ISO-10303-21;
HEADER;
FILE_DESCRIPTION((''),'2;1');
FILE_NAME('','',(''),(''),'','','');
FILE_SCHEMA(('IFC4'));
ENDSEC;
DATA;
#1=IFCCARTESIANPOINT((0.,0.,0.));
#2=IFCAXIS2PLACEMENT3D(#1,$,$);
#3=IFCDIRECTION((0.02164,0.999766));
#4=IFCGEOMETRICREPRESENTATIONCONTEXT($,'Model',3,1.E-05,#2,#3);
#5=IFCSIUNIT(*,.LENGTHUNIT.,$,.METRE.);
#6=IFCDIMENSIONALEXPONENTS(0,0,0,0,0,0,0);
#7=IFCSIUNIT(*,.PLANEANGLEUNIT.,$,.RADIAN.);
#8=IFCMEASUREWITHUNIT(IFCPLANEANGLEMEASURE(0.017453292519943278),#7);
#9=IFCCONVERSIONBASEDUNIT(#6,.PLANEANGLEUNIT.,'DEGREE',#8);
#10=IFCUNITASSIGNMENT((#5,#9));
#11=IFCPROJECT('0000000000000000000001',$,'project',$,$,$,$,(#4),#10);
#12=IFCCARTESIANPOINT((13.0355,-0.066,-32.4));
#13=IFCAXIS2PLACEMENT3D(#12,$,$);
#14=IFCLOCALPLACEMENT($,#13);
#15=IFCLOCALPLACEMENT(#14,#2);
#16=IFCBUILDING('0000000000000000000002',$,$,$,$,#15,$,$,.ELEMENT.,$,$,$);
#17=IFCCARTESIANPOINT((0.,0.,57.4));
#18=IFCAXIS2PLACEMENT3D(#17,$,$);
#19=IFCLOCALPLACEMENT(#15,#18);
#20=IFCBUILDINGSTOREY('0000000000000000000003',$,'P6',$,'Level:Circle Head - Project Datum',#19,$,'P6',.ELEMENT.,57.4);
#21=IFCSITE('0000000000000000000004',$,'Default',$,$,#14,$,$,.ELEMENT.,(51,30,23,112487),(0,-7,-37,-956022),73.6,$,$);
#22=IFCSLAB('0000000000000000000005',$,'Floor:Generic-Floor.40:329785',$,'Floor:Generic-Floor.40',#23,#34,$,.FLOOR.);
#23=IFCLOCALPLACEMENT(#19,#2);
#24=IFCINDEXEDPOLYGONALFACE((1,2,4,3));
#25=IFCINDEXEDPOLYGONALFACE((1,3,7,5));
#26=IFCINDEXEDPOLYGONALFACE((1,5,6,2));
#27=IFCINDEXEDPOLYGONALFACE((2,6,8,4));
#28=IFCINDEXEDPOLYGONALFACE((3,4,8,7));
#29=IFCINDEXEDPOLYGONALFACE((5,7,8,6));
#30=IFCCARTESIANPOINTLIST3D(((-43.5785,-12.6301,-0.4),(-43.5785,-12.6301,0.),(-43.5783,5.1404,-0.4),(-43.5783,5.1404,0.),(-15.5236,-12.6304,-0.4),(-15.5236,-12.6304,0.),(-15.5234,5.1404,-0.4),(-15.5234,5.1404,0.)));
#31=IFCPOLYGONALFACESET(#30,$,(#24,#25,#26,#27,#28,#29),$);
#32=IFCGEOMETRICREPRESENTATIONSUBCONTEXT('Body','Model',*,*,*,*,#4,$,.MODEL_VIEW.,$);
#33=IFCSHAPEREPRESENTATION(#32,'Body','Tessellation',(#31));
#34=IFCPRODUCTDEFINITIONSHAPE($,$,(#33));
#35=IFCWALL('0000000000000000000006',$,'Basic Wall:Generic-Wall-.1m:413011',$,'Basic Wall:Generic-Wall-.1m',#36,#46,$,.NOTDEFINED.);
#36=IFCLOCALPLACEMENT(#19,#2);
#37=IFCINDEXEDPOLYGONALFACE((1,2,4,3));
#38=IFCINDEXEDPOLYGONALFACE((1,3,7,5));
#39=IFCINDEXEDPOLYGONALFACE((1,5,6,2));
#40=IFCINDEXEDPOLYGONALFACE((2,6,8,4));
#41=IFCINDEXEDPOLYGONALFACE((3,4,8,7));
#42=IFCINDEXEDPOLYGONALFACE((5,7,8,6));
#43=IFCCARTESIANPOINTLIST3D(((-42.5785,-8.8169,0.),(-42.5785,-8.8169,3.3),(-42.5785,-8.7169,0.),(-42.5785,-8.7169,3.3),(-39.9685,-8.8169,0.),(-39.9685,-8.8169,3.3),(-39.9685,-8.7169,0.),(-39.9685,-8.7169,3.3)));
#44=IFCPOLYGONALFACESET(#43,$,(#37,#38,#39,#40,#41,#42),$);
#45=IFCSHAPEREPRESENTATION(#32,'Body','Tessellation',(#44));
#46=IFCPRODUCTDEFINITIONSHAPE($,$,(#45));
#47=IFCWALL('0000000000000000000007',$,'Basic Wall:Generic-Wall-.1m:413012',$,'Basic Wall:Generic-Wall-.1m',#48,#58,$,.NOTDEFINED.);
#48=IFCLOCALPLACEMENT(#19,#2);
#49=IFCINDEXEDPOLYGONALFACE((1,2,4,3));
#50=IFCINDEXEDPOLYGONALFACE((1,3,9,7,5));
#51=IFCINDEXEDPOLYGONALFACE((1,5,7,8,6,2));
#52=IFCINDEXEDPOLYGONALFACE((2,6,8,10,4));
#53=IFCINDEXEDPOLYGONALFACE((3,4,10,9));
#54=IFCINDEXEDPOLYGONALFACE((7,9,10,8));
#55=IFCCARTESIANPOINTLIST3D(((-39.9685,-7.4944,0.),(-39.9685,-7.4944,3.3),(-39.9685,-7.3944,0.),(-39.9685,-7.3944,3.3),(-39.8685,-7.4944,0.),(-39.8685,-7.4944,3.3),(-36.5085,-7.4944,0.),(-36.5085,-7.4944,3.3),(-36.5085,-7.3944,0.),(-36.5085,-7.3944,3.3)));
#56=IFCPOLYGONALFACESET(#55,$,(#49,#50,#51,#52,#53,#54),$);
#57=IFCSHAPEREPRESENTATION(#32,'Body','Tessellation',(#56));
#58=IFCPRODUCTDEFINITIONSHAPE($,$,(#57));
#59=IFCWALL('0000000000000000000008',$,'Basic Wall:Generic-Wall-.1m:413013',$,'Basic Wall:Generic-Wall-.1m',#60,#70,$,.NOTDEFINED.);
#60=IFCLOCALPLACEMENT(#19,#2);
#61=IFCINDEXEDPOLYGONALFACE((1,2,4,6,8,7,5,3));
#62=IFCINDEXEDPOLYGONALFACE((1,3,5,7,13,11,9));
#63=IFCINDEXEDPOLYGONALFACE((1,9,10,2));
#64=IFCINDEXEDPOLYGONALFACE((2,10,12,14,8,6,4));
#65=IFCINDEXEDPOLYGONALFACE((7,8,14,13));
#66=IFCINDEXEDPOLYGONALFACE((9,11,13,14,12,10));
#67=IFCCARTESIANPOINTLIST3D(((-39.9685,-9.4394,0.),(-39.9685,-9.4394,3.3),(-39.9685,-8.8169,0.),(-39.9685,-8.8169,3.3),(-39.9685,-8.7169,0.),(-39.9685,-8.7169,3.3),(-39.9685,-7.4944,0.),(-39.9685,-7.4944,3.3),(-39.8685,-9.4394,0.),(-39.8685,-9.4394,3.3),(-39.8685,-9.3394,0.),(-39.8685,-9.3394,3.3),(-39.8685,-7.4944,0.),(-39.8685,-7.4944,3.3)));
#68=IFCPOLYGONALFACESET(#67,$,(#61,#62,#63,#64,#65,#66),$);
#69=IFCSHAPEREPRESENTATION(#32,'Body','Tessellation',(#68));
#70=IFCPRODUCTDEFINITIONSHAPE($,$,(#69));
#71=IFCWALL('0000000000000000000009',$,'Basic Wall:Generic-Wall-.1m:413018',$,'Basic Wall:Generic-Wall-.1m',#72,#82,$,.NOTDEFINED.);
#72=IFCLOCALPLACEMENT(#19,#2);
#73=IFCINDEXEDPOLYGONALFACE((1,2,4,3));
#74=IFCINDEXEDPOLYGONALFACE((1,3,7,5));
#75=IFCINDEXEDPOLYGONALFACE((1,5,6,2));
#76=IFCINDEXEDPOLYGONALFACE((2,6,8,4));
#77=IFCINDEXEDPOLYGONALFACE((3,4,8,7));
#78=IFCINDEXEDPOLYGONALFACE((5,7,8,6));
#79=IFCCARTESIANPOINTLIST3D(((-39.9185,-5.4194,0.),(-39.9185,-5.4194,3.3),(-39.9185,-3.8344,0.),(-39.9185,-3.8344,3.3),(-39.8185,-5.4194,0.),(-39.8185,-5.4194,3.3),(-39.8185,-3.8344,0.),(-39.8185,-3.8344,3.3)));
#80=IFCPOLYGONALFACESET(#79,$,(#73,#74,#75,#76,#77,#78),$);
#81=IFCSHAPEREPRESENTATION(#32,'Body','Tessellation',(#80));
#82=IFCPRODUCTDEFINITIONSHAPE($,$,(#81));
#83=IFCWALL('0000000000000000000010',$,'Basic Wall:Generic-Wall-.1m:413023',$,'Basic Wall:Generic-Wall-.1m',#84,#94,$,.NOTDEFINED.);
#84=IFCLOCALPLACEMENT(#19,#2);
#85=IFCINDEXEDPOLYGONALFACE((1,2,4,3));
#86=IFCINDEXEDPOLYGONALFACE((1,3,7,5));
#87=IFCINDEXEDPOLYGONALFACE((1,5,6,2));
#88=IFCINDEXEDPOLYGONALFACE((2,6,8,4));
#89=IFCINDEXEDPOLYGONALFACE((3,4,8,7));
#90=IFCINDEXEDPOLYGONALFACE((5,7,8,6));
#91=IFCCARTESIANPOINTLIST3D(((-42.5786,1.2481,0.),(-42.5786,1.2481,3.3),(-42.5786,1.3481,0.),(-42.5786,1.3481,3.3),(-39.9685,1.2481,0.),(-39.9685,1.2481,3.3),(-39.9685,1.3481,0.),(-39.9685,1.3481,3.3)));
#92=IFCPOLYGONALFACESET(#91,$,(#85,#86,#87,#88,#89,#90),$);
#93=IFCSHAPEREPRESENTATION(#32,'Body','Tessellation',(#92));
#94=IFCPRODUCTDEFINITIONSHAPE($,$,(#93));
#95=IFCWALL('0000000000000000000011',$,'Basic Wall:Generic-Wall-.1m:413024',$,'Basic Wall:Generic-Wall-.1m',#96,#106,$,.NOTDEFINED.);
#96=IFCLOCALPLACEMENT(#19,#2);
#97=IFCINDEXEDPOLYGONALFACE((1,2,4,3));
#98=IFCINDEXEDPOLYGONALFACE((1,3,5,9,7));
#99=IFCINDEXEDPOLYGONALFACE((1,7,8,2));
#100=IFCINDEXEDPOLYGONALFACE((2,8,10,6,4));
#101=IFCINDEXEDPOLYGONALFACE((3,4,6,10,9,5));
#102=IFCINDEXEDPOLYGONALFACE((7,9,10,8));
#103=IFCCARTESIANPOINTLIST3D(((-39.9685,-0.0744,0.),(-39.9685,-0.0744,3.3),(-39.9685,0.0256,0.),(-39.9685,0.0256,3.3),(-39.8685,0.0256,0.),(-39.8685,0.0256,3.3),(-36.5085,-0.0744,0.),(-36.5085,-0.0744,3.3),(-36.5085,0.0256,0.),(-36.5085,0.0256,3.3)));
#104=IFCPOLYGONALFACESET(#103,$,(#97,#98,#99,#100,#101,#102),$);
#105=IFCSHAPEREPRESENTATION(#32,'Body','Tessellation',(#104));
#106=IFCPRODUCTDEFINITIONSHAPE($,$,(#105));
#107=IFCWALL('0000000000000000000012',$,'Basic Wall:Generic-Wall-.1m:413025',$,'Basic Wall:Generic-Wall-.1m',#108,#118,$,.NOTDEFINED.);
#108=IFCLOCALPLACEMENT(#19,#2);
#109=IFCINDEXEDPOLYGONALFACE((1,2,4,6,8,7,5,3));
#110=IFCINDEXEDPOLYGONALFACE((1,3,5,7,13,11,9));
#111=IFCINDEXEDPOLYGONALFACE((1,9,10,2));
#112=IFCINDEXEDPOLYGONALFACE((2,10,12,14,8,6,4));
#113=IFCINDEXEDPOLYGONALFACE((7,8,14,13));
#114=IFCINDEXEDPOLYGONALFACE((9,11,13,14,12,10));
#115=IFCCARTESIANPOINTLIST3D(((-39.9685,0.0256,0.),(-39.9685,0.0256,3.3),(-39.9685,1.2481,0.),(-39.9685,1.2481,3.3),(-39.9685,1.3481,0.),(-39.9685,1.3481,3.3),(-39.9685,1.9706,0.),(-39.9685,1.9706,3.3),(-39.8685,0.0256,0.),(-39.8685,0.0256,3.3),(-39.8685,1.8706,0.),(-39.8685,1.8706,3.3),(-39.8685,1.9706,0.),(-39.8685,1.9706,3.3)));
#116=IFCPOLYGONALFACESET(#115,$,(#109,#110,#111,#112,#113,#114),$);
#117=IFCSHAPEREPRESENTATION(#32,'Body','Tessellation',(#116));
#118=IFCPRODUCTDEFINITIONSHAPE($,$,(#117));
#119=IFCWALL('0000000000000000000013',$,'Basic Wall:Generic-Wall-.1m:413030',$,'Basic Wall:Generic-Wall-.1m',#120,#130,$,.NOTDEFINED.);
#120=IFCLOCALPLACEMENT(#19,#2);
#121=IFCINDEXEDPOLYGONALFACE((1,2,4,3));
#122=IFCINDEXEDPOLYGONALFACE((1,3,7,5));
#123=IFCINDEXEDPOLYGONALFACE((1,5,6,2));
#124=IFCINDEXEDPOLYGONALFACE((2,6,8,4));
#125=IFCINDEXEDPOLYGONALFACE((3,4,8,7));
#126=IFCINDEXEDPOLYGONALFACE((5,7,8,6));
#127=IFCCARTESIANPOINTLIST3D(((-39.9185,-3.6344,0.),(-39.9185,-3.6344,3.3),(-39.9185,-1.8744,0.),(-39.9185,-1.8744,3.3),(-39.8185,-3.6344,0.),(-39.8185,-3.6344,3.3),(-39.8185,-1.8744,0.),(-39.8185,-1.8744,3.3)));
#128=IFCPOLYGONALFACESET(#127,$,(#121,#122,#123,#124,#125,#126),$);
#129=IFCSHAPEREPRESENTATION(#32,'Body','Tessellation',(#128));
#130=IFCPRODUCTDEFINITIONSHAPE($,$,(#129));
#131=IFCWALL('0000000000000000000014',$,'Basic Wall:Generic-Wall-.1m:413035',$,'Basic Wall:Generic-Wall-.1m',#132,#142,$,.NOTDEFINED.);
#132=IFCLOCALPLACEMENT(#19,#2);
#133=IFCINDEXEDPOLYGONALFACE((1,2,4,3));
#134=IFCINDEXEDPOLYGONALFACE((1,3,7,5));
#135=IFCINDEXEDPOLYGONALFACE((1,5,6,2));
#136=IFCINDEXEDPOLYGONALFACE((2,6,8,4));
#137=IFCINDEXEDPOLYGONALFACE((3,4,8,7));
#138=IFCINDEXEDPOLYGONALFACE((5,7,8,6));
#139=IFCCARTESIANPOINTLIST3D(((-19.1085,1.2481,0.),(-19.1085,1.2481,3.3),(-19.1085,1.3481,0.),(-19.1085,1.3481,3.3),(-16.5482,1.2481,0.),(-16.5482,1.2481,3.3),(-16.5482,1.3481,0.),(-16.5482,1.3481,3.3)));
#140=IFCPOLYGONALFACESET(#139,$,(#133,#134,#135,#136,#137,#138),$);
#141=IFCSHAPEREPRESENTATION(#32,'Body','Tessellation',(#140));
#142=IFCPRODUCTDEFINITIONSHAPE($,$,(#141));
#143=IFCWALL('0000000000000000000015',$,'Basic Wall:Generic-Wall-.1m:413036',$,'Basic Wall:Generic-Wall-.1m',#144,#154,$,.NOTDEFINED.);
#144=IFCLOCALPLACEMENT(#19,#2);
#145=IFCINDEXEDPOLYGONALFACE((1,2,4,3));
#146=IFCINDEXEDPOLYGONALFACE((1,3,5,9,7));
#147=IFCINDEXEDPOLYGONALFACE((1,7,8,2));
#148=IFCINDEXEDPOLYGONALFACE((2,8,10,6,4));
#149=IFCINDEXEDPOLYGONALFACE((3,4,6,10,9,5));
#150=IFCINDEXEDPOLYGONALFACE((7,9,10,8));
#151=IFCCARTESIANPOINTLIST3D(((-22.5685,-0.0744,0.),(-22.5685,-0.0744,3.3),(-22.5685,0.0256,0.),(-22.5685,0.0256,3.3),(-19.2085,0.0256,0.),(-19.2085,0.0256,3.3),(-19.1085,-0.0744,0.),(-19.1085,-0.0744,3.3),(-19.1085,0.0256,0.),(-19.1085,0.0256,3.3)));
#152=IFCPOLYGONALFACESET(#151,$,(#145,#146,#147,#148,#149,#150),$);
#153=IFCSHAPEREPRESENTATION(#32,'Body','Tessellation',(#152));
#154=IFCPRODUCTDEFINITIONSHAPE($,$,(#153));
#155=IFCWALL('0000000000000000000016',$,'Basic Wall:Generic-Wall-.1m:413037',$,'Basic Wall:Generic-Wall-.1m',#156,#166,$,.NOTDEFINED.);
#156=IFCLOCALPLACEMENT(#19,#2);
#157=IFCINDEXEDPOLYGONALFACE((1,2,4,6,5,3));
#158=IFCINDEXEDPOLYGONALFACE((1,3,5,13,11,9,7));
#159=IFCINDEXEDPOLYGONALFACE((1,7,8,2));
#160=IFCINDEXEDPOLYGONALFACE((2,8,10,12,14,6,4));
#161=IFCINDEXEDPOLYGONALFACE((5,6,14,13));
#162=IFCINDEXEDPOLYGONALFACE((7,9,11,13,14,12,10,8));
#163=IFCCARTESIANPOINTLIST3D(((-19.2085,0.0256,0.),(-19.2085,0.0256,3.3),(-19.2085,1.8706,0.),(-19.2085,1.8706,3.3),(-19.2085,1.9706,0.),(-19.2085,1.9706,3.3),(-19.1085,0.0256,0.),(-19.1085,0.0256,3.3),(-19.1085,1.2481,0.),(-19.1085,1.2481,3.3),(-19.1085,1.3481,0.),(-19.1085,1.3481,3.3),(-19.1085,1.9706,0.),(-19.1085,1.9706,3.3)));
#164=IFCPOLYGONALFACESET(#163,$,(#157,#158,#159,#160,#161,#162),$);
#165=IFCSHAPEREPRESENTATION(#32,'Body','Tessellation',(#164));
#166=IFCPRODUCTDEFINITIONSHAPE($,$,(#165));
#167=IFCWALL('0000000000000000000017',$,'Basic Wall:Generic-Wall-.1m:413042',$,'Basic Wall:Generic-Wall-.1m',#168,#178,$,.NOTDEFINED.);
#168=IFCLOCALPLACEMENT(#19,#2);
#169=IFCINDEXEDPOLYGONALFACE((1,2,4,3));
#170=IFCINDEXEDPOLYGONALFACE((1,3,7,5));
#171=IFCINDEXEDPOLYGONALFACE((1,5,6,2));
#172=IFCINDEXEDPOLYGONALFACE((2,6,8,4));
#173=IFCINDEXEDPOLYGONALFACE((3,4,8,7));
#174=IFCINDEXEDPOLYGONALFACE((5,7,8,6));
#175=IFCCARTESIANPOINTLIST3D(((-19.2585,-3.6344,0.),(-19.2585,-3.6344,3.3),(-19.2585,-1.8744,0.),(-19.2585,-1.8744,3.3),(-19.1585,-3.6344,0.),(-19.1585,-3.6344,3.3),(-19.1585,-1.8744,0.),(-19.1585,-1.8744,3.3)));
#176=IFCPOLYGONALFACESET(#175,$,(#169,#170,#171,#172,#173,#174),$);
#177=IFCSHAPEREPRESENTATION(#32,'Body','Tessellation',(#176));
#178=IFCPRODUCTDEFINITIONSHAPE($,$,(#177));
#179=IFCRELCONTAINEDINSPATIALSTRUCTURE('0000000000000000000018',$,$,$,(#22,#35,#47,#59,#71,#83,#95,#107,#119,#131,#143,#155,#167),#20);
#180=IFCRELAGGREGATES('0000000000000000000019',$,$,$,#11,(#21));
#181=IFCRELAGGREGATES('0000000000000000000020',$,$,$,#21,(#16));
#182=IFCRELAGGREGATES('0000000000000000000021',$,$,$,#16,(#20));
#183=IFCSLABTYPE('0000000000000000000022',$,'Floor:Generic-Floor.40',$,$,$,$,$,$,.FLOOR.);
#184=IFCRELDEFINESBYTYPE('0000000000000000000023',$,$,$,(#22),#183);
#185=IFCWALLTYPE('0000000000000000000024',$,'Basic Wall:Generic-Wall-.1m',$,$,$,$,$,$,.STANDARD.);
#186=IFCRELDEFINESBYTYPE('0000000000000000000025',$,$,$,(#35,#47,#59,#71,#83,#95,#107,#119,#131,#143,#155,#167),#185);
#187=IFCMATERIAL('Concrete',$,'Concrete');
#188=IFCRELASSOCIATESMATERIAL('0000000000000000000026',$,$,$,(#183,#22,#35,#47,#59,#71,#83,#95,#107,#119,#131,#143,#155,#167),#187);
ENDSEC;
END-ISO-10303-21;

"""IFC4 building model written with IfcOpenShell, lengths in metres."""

from ifc_helpers import new_model, entity, si_unit, converted_unit, direction, frame, origin, place, context, subcontext, project, spatial, indexed_curve, outline, extrude, material, type_object, element, save


model = new_model("IFC4")

# Units and contexts
model_context = context("Model", 3, precision=1e-05, world=origin(), true_north=direction((0.02164, 0.999766)))
body_context = subcontext(model_context, "Body", "Model", "MODEL_VIEW")
ifc_project = project(units=[si_unit("LENGTHUNIT", "METRE"), converted_unit("PLANEANGLEUNIT", "DEGREE", entity("IfcPlaneAngleMeasure", 0.017453292519943278), si_unit("PLANEANGLEUNIT", "RADIAN"), dimensions=[0, 0, 0, 0, 0, 0, 0])], contexts=[model_context])

# Site, building, storey
site_placement = place(None, frame((13.0355, -0.066, -32.4)))
site = spatial("IfcSite", under=ifc_project, at=site_placement, Name="Default", CompositionType="ELEMENT", RefLatitude=(51, 30, 23, 112487), RefLongitude=(0, -7, -37, -956022), RefElevation=73.6)
building_placement = place(site_placement, origin())
building = spatial("IfcBuilding", under=site, at=building_placement, CompositionType="ELEMENT")
storey_placement = place(building_placement, frame((0.0, 0.0, 57.4)))
storey = spatial("IfcBuildingStorey", under=building, at=storey_placement, Name="P6", ObjectType="Level:Circle Head - Project Datum", LongName="P6", CompositionType="ELEMENT", Elevation=57.4)

# Shared definitions
ifc_material = material(Name="Concrete", Category="Concrete")

# Slab
slab_type = type_object("IfcSlabType", Name="Floor:Generic-Floor.40", PredefinedType="FLOOR", material=ifc_material)
slab_placement = place(storey_placement, origin())
element("IfcSlab", 1, at=slab_placement, inside=storey, type_object=slab_type, material=ifc_material, Name="Floor:Generic-Floor.40:329785", ObjectType="Floor:Generic-Floor.40", PredefinedType="FLOOR", context=body_context, shape_type="SweptSolid", body=[
    extrude(outline(indexed_curve([(-14.0274, -8.8853), (14.0275, -8.8853), (14.0274, 8.8855), (-14.0275, 8.8852), (-14.0274, -8.8853)], self_intersect=False)), frame((-29.5509, -3.7449, 0.0), z_axis=(0.0, 0.0, -1.0), x_axis=(1.0, 0.0, 0.0)), (0.0, 0.0, 1.0), 0.4),
])

# Walls
wall_type = type_object("IfcWallType", Name="Basic Wall:Generic-Wall-.1m", PredefinedType="STANDARD")
wall_1_placement = place(storey_placement, frame((-39.9685, -8.7669, 0.0), z_axis=(0.0, 0.0, 1.0), x_axis=(-1.0, 0.0, 0.0)))
element("IfcWall", 2, at=wall_1_placement, inside=storey, type_object=wall_type, material=ifc_material, Name="Basic Wall:Generic-Wall-.1m:413011", ObjectType="Basic Wall:Generic-Wall-.1m", PredefinedType="NOTDEFINED", context=body_context, shape_type="SweptSolid", body=[
    extrude(outline(indexed_curve([(2.61, -0.05), (2.61, 0.05), (0.0, 0.05), (0.0, -0.05), (2.61, -0.05)], self_intersect=False)), origin(), (0.0, 0.0, 1.0), 3.3),
])
wall_2_placement = place(storey_placement, frame((-36.5085, -7.4444, 0.0), z_axis=(0.0, 0.0, 1.0), x_axis=(-1.0, 0.0, 0.0)))
element("IfcWall", 3, at=wall_2_placement, inside=storey, type_object=wall_type, material=ifc_material, Name="Basic Wall:Generic-Wall-.1m:413012", ObjectType="Basic Wall:Generic-Wall-.1m", PredefinedType="NOTDEFINED", context=body_context, shape_type="SweptSolid", body=[
    extrude(outline(indexed_curve([(3.46, -0.05), (3.46, 0.05), (3.36, 0.05), (0.0, 0.05), (0.0, -0.05), (3.46, -0.05)], self_intersect=False)), origin(), (0.0, 0.0, 1.0), 3.3),
])
wall_3_placement = place(storey_placement, frame((-39.9185, -7.4944, 0.0), z_axis=(0.0, 0.0, 1.0), x_axis=(0.0, -1.0, 0.0)))
element("IfcWall", 4, at=wall_3_placement, inside=storey, type_object=wall_type, material=ifc_material, Name="Basic Wall:Generic-Wall-.1m:413013", ObjectType="Basic Wall:Generic-Wall-.1m", PredefinedType="NOTDEFINED", context=body_context, shape_type="SweptSolid", body=[
    extrude(outline(indexed_curve([(1.945, -0.05), (1.945, 0.05), (1.845, 0.05), (0.0, 0.05), (0.0, -0.05), (1.2225, -0.05), (1.3225, -0.05), (1.945, -0.05)], self_intersect=False)), origin(), (0.0, 0.0, 1.0), 3.3),
])
wall_4_placement = place(storey_placement, frame((-39.8685, -5.4194, 0.0), z_axis=(0.0, 0.0, 1.0), x_axis=(0.0, 1.0, 0.0)))
element("IfcWall", 5, at=wall_4_placement, inside=storey, type_object=wall_type, material=ifc_material, Name="Basic Wall:Generic-Wall-.1m:413018", ObjectType="Basic Wall:Generic-Wall-.1m", PredefinedType="NOTDEFINED", context=body_context, shape_type="SweptSolid", body=[
    extrude(outline(indexed_curve([(1.585, -0.05), (1.585, 0.05), (0.0, 0.05), (0.0, -0.05), (1.585, -0.05)], self_intersect=False)), origin(), (0.0, 0.0, 1.0), 3.3),
])
wall_5_placement = place(storey_placement, frame((-39.9685, 1.2981, 0.0), z_axis=(0.0, 0.0, 1.0), x_axis=(-1.0, 0.0, 0.0)))
element("IfcWall", 6, at=wall_5_placement, inside=storey, type_object=wall_type, material=ifc_material, Name="Basic Wall:Generic-Wall-.1m:413023", ObjectType="Basic Wall:Generic-Wall-.1m", PredefinedType="NOTDEFINED", context=body_context, shape_type="SweptSolid", body=[
    extrude(outline(indexed_curve([(2.6101, -0.05), (2.6101, 0.05), (0.0, 0.05), (0.0, -0.05), (2.6101, -0.05)], self_intersect=False)), origin(), (0.0, 0.0, 1.0), 3.3),
])
wall_6_placement = place(storey_placement, frame((-36.5085, -0.0244, 0.0), z_axis=(0.0, 0.0, 1.0), x_axis=(-1.0, 0.0, 0.0)))
element("IfcWall", 7, at=wall_6_placement, inside=storey, type_object=wall_type, material=ifc_material, Name="Basic Wall:Generic-Wall-.1m:413024", ObjectType="Basic Wall:Generic-Wall-.1m", PredefinedType="NOTDEFINED", context=body_context, shape_type="SweptSolid", body=[
    extrude(outline(indexed_curve([(3.46, -0.05), (3.46, 0.05), (0.0, 0.05), (0.0, -0.05), (3.36, -0.05), (3.46, -0.05)], self_intersect=False)), origin(), (0.0, 0.0, 1.0), 3.3),
])
wall_7_placement = place(storey_placement, frame((-39.9185, 0.0256, 0.0), z_axis=(0.0, 0.0, 1.0), x_axis=(0.0, 1.0, 0.0)))
element("IfcWall", 8, at=wall_7_placement, inside=storey, type_object=wall_type, material=ifc_material, Name="Basic Wall:Generic-Wall-.1m:413025", ObjectType="Basic Wall:Generic-Wall-.1m", PredefinedType="NOTDEFINED", context=body_context, shape_type="SweptSolid", body=[
    extrude(outline(indexed_curve([(1.945, -0.05), (1.945, 0.05), (1.3225, 0.05), (1.2225, 0.05), (0.0, 0.05), (0.0, -0.05), (1.845, -0.05), (1.945, -0.05)], self_intersect=False)), origin(), (0.0, 0.0, 1.0), 3.3),
])
wall_8_placement = place(storey_placement, frame((-39.8685, -1.8744, 0.0), z_axis=(0.0, 0.0, 1.0), x_axis=(0.0, -1.0, 0.0)))
element("IfcWall", 9, at=wall_8_placement, inside=storey, type_object=wall_type, material=ifc_material, Name="Basic Wall:Generic-Wall-.1m:413030", ObjectType="Basic Wall:Generic-Wall-.1m", PredefinedType="NOTDEFINED", context=body_context, shape_type="SweptSolid", body=[
    extrude(outline(indexed_curve([(1.76, -0.05), (1.76, 0.05), (0.0, 0.05), (0.0, -0.05), (1.76, -0.05)], self_intersect=False)), origin(), (0.0, 0.0, 1.0), 3.3),
])
wall_9_placement = place(storey_placement, frame((-19.1085, 1.2981, 0.0)))
element("IfcWall", 10, at=wall_9_placement, inside=storey, type_object=wall_type, material=ifc_material, Name="Basic Wall:Generic-Wall-.1m:413035", ObjectType="Basic Wall:Generic-Wall-.1m", PredefinedType="NOTDEFINED", context=body_context, shape_type="SweptSolid", body=[
    extrude(outline(indexed_curve([(2.5602, -0.05), (2.5602, 0.05), (0.0, 0.05), (0.0, -0.05), (2.5602, -0.05)], self_intersect=False)), origin(), (0.0, 0.0, 1.0), 3.3),
])
wall_10_placement = place(storey_placement, frame((-22.5685, -0.0244, 0.0)))
element("IfcWall", 11, at=wall_10_placement, inside=storey, type_object=wall_type, material=ifc_material, Name="Basic Wall:Generic-Wall-.1m:413036", ObjectType="Basic Wall:Generic-Wall-.1m", PredefinedType="NOTDEFINED", context=body_context, shape_type="SweptSolid", body=[
    extrude(outline(indexed_curve([(3.46, -0.05), (3.46, 0.05), (3.36, 0.05), (0.0, 0.05), (0.0, -0.05), (3.46, -0.05)], self_intersect=False)), origin(), (0.0, 0.0, 1.0), 3.3),
])
wall_11_placement = place(storey_placement, frame((-19.1585, 0.0256, 0.0), z_axis=(0.0, 0.0, 1.0), x_axis=(0.0, 1.0, 0.0)))
element("IfcWall", 12, at=wall_11_placement, inside=storey, type_object=wall_type, material=ifc_material, Name="Basic Wall:Generic-Wall-.1m:413037", ObjectType="Basic Wall:Generic-Wall-.1m", PredefinedType="NOTDEFINED", context=body_context, shape_type="SweptSolid", body=[
    extrude(outline(indexed_curve([(1.945, -0.05), (1.945, 0.05), (1.845, 0.05), (0.0, 0.05), (0.0, -0.05), (1.2225, -0.05), (1.3225, -0.05), (1.945, -0.05)], self_intersect=False)), origin(), (0.0, 0.0, 1.0), 3.3),
])
wall_12_placement = place(storey_placement, frame((-19.2085, -1.8744, 0.0), z_axis=(0.0, 0.0, 1.0), x_axis=(0.0, -1.0, 0.0)))
element("IfcWall", 13, at=wall_12_placement, inside=storey, type_object=wall_type, material=ifc_material, Name="Basic Wall:Generic-Wall-.1m:413042", ObjectType="Basic Wall:Generic-Wall-.1m", PredefinedType="NOTDEFINED", context=body_context, shape_type="SweptSolid", body=[
    extrude(outline(indexed_curve([(1.76, -0.05), (1.76, 0.05), (0.0, 0.05), (0.0, -0.05), (1.76, -0.05)], self_intersect=False)), origin(), (0.0, 0.0, 1.0), 3.3),
])

save(model, "model.ifc")
